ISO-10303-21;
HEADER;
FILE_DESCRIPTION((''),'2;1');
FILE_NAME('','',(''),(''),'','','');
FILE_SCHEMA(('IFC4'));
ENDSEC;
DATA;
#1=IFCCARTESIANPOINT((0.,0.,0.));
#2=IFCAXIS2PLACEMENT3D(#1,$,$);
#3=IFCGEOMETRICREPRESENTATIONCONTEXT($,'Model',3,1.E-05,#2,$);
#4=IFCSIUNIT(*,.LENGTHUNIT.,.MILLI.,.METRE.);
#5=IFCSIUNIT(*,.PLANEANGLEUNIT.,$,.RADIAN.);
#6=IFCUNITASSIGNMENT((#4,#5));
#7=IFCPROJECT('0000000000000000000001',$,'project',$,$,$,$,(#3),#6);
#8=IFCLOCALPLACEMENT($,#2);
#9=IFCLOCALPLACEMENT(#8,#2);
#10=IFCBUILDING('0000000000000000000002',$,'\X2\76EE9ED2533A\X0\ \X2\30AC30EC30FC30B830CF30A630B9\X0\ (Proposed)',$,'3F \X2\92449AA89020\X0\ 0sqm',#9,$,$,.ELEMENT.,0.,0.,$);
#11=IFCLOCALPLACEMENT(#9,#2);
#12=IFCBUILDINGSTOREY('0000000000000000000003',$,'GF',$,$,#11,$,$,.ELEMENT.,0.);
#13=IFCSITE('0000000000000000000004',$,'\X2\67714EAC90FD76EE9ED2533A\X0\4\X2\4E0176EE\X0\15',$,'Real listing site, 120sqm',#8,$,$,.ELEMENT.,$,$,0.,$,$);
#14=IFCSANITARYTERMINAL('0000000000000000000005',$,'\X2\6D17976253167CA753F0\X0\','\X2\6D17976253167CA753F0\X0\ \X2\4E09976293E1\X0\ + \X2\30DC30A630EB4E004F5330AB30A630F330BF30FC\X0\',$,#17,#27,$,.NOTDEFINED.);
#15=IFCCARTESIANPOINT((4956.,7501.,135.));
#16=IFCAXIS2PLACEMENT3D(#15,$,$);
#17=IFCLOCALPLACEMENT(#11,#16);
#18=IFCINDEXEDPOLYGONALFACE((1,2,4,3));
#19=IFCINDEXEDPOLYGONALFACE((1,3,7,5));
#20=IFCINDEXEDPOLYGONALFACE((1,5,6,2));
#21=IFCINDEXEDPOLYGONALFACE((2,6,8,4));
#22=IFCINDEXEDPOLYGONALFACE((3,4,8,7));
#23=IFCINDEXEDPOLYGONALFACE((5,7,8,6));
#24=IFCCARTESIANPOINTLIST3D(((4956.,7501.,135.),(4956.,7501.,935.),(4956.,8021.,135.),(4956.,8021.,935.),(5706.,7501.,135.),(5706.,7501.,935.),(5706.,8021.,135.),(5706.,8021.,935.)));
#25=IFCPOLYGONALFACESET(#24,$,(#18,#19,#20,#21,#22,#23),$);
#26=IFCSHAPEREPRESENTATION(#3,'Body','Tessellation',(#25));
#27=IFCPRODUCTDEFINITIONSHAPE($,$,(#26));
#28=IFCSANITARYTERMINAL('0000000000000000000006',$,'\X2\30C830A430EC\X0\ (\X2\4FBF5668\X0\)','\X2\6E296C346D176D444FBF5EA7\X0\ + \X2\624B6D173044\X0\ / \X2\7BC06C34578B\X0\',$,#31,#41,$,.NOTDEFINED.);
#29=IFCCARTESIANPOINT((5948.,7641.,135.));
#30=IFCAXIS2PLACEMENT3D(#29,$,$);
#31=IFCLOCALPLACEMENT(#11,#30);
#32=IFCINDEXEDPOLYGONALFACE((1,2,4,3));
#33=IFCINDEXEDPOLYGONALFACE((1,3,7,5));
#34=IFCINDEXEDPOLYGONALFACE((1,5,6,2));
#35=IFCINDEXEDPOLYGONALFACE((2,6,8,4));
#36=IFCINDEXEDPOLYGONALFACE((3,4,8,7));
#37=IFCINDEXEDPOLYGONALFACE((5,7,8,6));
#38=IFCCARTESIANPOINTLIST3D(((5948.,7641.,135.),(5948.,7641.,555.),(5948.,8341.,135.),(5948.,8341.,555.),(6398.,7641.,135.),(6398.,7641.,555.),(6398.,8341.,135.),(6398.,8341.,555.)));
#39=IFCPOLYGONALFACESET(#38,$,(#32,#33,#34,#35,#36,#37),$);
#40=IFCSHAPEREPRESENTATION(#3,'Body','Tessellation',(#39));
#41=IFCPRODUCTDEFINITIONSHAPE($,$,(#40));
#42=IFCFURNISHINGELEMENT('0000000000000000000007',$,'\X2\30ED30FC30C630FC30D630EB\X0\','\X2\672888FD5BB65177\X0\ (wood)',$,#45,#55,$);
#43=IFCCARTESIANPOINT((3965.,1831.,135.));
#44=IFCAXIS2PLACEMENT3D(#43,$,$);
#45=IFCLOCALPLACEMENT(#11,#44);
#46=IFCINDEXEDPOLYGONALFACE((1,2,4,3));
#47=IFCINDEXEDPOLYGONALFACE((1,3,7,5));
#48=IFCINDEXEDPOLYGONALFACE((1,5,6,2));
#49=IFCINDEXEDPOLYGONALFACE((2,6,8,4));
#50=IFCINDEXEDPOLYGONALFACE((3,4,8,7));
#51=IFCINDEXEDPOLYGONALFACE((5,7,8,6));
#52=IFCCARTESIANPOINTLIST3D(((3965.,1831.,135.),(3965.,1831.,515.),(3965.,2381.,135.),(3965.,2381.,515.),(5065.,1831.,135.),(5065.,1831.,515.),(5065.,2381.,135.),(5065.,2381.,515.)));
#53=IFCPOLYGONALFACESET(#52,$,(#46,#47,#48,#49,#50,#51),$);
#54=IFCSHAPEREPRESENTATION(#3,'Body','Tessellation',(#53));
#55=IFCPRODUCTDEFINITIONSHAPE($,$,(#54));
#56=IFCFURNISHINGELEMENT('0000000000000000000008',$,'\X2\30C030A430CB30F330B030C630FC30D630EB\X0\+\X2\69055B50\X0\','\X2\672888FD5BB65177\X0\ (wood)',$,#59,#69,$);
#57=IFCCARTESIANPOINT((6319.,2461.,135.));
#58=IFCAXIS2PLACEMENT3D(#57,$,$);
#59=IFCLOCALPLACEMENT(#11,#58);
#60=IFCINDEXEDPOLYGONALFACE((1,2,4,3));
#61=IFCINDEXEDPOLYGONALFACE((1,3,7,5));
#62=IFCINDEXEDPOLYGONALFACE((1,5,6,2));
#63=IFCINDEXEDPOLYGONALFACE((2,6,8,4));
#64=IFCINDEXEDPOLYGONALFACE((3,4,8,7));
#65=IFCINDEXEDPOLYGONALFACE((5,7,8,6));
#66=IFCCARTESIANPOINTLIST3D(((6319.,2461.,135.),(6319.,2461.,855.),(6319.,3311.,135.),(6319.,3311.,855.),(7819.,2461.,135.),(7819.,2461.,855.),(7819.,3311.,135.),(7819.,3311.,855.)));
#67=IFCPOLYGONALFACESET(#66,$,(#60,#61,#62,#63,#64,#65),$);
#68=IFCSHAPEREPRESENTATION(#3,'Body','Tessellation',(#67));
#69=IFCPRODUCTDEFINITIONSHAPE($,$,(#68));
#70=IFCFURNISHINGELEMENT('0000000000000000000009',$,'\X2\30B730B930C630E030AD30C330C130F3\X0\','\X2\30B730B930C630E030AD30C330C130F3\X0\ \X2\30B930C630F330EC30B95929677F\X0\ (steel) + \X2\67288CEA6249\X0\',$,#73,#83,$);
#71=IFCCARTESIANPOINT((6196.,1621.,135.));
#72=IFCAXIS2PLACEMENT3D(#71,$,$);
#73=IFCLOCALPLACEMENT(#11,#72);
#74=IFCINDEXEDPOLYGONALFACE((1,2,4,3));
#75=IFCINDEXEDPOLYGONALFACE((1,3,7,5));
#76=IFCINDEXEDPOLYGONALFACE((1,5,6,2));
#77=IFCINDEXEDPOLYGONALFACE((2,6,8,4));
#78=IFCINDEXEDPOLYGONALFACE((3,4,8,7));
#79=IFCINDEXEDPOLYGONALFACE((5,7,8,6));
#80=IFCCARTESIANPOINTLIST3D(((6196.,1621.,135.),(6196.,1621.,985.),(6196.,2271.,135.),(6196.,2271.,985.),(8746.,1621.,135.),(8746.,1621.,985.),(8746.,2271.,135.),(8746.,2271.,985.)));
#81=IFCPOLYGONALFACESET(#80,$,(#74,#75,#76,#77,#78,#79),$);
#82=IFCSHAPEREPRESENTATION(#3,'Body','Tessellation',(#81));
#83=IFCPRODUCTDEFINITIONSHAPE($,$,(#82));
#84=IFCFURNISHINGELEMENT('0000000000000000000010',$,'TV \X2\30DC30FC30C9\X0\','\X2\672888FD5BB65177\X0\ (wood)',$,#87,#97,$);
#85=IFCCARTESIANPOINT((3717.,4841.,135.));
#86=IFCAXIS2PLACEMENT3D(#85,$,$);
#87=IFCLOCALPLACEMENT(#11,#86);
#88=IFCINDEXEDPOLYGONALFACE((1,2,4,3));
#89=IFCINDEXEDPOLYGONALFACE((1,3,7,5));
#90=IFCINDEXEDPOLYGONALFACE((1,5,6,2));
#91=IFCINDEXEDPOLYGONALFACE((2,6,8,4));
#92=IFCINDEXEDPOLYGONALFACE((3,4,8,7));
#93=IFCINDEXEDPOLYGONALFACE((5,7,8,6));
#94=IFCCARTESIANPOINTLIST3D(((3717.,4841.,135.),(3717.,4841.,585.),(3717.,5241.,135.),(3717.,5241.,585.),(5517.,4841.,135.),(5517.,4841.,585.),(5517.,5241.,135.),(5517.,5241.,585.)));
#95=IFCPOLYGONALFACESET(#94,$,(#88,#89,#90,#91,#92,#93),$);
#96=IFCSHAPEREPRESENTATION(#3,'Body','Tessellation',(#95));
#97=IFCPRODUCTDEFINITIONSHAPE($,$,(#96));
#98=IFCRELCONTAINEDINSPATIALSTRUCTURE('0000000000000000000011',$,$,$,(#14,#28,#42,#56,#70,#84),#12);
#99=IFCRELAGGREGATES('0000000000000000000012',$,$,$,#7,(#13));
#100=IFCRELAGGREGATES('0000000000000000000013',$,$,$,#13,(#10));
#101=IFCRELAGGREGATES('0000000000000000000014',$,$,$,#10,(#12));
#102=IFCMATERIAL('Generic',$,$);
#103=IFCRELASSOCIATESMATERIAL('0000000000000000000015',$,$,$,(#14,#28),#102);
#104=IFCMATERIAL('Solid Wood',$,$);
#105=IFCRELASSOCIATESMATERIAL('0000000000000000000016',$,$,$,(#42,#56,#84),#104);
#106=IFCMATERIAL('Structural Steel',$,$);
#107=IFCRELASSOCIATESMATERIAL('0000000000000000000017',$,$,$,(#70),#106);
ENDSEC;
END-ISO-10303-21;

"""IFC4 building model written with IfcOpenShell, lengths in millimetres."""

from ifc_helpers import new_model, si_unit, frame, frame_2d, origin, place, context, project, spatial, rectangle, extrude, material, element, save


model = new_model("IFC4")

# Units and contexts
model_context = context("Model", 3, precision=1e-05, world=origin())
ifc_project = project(units=[si_unit("LENGTHUNIT", "METRE", prefix="MILLI"), si_unit("PLANEANGLEUNIT", "RADIAN")], contexts=[model_context])

# Site, building, storey
site_placement = place(None, origin())
site = spatial("IfcSite", under=ifc_project, at=site_placement, Name="東京都目黒区4丁目15", ObjectType="Real listing site, 120sqm", CompositionType="ELEMENT", RefElevation=0.0)
building_placement = place(site_placement, origin())
building = spatial("IfcBuilding", under=site, at=building_placement, Name="目黒区 ガレージハウス (Proposed)", ObjectType="3F 鉄骨造 0sqm", CompositionType="ELEMENT", ElevationOfRefHeight=0.0, ElevationOfTerrain=0.0)
storey_placement = place(building_placement, origin())
storey = spatial("IfcBuildingStorey", under=building, at=storey_placement, Name="GF", CompositionType="ELEMENT", Elevation=0.0)

# Shared definitions
ifc_material_1 = material(Name="Solid Wood")

# Sanitary terminals
ifc_material_2 = material(Name="Generic")
sanitary_terminal_1_placement = place(storey_placement, frame((4956.0, 7501.0, 135.0)))
element("IfcSanitaryTerminal", 1, at=sanitary_terminal_1_placement, inside=storey, material=ifc_material_2, Name="洗面化粧台", Description="洗面化粧台 三面鏡 + ボウル一体カウンター", PredefinedType="NOTDEFINED", context=model_context, shape_type="SweptSolid", body=[
    extrude(rectangle(XDim=750.0, YDim=520.0, at=frame_2d((375.0, 260.0))), frame((4956.0, 7501.0, 135.0)), (0.0, 0.0, 1.0), 800.0),
])
sanitary_terminal_2_placement = place(storey_placement, frame((5948.0, 7641.0, 135.0)))
element("IfcSanitaryTerminal", 2, at=sanitary_terminal_2_placement, inside=storey, material=ifc_material_2, Name="トイレ (便器)", Description="温水洗浄便座 + 手洗い / 節水型", PredefinedType="NOTDEFINED", context=model_context, shape_type="SweptSolid", body=[
    extrude(rectangle(XDim=450.0, YDim=700.0, at=frame_2d((225.0, 350.0))), frame((5948.0, 7641.0, 135.0)), (0.0, 0.0, 1.0), 420.0),
])

# Furnishing elements
furnishing_1_placement = place(storey_placement, frame((3965.0, 1831.0, 135.0)))
element("IfcFurnishingElement", 3, at=furnishing_1_placement, inside=storey, material=ifc_material_1, Name="ローテーブル", Description="木製家具 (wood)", context=model_context, shape_type="SweptSolid", body=[
    extrude(rectangle(XDim=1100.0, YDim=550.0, at=frame_2d((550.0, 275.0))), frame((3965.0, 1831.0, 135.0)), (0.0, 0.0, 1.0), 380.0),
])
furnishing_2_placement = place(storey_placement, frame((6319.0, 2461.0, 135.0)))
element("IfcFurnishingElement", 4, at=furnishing_2_placement, inside=storey, material=ifc_material_1, Name="ダイニングテーブル+椅子", Description="木製家具 (wood)", context=model_context, shape_type="SweptSolid", body=[
    extrude(rectangle(XDim=1500.0, YDim=850.0, at=frame_2d((750.0, 425.0))), frame((6319.0, 2461.0, 135.0)), (0.0, 0.0, 1.0), 720.0),
])
ifc_material_3 = material(Name="Structural Steel")
furnishing_3_placement = place(storey_placement, frame((6196.0, 1621.0, 135.0)))
element("IfcFurnishingElement", 5, at=furnishing_3_placement, inside=storey, material=ifc_material_3, Name="システムキッチン", Description="システムキッチン ステンレス天板 (steel) + 木質扉", context=model_context, shape_type="SweptSolid", body=[
    extrude(rectangle(XDim=2550.0, YDim=650.0, at=frame_2d((1275.0, 325.0))), frame((6196.0, 1621.0, 135.0)), (0.0, 0.0, 1.0), 850.0),
])
furnishing_4_placement = place(storey_placement, frame((3717.0, 4841.0, 135.0)))
element("IfcFurnishingElement", 6, at=furnishing_4_placement, inside=storey, material=ifc_material_1, Name="TV ボード", Description="木製家具 (wood)", context=model_context, shape_type="SweptSolid", body=[
    extrude(rectangle(XDim=1800.0, YDim=400.0, at=frame_2d((900.0, 200.0))), frame((3717.0, 4841.0, 135.0)), (0.0, 0.0, 1.0), 450.0),
])

save(model, "model.ifc")
